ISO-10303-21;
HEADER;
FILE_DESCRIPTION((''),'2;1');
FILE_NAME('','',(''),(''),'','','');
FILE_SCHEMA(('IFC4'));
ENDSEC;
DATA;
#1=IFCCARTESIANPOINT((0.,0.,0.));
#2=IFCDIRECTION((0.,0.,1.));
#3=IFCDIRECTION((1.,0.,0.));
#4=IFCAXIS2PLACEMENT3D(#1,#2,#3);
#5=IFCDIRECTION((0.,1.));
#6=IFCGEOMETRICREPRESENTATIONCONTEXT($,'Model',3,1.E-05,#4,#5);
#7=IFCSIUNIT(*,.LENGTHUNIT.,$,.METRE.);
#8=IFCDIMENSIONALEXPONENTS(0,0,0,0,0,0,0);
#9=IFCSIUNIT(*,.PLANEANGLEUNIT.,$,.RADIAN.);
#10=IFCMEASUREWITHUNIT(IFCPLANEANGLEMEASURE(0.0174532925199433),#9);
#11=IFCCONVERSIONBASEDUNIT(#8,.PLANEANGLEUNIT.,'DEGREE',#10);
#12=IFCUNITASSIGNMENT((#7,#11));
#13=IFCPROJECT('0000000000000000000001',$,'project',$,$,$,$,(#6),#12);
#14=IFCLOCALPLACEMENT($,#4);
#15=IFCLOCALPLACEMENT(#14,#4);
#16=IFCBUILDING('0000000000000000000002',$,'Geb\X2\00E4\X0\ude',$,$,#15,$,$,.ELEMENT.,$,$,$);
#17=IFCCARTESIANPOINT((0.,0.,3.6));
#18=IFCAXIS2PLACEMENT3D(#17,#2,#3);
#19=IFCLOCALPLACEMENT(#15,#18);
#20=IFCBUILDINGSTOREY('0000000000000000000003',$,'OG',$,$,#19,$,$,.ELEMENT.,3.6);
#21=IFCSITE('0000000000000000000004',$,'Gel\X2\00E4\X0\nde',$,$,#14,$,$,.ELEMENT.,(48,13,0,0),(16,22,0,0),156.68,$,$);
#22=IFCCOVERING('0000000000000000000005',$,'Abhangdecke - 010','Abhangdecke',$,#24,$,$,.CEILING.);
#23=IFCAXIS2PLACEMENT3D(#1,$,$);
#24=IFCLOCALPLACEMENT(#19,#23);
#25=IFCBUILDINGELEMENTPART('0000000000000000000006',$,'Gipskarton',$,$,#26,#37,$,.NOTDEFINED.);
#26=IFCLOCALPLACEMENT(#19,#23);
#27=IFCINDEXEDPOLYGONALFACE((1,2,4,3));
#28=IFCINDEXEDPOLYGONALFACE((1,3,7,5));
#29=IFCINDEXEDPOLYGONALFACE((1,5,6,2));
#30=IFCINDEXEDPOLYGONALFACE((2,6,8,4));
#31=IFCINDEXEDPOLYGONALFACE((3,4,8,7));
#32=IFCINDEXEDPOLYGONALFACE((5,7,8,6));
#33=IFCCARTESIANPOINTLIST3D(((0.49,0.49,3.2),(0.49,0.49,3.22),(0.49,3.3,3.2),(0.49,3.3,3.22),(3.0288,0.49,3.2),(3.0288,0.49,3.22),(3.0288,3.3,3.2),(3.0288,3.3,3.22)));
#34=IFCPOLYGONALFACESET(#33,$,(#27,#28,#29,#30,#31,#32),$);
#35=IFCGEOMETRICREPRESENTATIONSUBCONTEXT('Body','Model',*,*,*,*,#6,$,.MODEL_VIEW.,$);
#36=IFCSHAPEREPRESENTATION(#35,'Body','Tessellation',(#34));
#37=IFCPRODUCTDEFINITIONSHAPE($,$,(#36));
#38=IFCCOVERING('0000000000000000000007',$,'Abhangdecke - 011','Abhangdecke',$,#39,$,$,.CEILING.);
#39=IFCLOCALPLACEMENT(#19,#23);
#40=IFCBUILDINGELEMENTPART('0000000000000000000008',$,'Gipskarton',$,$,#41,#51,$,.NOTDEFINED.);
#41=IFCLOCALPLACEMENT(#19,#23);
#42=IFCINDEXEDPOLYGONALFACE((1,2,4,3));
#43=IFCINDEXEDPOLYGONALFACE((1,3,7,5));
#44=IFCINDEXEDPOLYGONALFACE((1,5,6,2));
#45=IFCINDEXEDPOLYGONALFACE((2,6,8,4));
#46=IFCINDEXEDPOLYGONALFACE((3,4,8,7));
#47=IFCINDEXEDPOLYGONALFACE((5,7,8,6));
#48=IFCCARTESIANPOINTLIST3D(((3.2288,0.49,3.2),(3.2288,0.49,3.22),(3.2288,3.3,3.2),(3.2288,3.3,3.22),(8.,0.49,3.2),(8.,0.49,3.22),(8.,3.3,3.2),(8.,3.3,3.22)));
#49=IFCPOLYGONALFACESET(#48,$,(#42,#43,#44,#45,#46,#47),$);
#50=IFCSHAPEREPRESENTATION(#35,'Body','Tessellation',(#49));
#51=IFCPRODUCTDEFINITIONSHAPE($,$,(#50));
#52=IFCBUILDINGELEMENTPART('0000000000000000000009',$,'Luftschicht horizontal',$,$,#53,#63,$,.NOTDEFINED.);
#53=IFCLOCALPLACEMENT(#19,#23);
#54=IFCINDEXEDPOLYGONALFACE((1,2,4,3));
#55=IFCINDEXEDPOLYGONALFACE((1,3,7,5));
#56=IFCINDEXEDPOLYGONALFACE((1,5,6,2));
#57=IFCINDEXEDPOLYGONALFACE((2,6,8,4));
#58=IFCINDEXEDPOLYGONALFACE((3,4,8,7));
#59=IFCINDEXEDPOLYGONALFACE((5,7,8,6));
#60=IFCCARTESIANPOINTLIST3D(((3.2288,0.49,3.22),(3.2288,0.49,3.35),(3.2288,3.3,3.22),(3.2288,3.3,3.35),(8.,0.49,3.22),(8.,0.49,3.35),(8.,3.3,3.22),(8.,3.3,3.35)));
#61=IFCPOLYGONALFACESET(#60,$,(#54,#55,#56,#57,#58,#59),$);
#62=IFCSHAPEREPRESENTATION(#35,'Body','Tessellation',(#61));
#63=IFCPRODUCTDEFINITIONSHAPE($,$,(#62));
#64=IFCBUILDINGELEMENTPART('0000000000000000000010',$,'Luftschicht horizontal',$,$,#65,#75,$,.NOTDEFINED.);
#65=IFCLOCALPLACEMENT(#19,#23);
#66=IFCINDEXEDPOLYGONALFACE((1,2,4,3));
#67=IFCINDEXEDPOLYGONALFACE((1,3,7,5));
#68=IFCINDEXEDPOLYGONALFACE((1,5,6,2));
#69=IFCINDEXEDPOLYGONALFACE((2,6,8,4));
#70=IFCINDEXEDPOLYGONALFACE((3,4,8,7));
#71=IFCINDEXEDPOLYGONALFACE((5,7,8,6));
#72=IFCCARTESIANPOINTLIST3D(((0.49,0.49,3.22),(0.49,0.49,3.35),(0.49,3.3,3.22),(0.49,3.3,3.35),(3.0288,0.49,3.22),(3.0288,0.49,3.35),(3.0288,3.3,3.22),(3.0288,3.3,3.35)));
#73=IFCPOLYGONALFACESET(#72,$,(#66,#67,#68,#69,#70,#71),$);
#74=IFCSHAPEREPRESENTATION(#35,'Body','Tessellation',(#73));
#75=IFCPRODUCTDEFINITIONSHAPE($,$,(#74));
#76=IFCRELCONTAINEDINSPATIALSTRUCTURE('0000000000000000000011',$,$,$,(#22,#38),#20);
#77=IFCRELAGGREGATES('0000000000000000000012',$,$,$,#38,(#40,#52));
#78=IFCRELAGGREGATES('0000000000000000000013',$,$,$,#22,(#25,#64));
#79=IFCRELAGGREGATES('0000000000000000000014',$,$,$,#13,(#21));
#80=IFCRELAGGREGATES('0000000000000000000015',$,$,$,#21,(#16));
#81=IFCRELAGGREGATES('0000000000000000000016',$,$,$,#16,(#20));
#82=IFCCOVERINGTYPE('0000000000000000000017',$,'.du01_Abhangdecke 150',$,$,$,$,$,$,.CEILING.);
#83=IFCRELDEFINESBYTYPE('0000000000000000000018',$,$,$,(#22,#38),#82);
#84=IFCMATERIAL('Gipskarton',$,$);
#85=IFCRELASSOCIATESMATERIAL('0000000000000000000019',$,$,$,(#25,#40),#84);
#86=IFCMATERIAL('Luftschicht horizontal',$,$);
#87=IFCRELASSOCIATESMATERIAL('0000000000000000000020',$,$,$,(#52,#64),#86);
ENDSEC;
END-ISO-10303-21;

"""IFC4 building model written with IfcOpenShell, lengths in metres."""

from ifc_helpers import new_model, entity, si_unit, converted_unit, direction, frame, origin_with_axes, place, context, subcontext, project, spatial, line, indexed_curve, outline, extrude, material, type_object, element, aggregate, save


model = new_model("IFC4")

# Units and contexts
model_context = context("Model", 3, precision=1e-05, world=origin_with_axes(), true_north=direction((0.0, 1.0)))
body_context = subcontext(model_context, "Body", "Model", "MODEL_VIEW")
ifc_project = project(units=[si_unit("LENGTHUNIT", "METRE"), converted_unit("PLANEANGLEUNIT", "DEGREE", entity("IfcPlaneAngleMeasure", 0.0174532925199433), si_unit("PLANEANGLEUNIT", "RADIAN"), dimensions=[0, 0, 0, 0, 0, 0, 0])], contexts=[model_context])

# Site, building, storey
site_placement = place(None, origin_with_axes())
site = spatial("IfcSite", under=ifc_project, at=site_placement, Name="Gelände", CompositionType="ELEMENT", RefLatitude=(48, 13, 0, 0), RefLongitude=(16, 22, 0, 0), RefElevation=156.68)
building_placement = place(site_placement, origin_with_axes())
building = spatial("IfcBuilding", under=site, at=building_placement, Name="Gebäude", CompositionType="ELEMENT")
storey_placement = place(building_placement, frame((0.0, 0.0, 3.6), z_axis=(0.0, 0.0, 1.0), x_axis=(1.0, 0.0, 0.0)))
storey = spatial("IfcBuildingStorey", under=building, at=storey_placement, Name="OG", CompositionType="ELEMENT", Elevation=3.6)

# Shared definitions
ifc_material_1 = material(Name="Gipskarton")
ifc_material_2 = material(Name="Luftschicht horizontal")

# Covering, building element part
covering_type_1 = type_object("IfcCoveringType", Name=".du01_Abhangdecke 150", PredefinedType="CEILING")
covering_1_placement = place(storey_placement, frame((0.49, 3.3, 3.35), z_axis=(0.0, 0.0, 1.0), x_axis=(1.0, 0.0, 0.0)))
covering_1 = element("IfcCovering", 1, at=covering_1_placement, inside=storey, type_object=covering_type_1, Name="Abhangdecke - 010", Description="Abhangdecke", PredefinedType="CEILING")
building_element_part_1_placement = place(covering_1_placement, origin_with_axes())
building_element_part_1 = element("IfcBuildingElementPart", 2, at=building_element_part_1_placement, material=ifc_material_1, Name="Gipskarton", PredefinedType="NOTDEFINED", context=body_context, shape_type="SweptSolid", body=[
    extrude(outline(indexed_curve([(0.0, 0.0), (0.0, -2.81), (2.5388, -2.81), (2.5388, 0.0)], segments=[line(1, 2, 3, 4, 1)])), frame((0.0, 0.0, -0.15), z_axis=(0.0, 0.0, 1.0), x_axis=(1.0, 0.0, 0.0)), (0.0, 0.0, 1.0), 0.02),
])

# Covering, building element parts
covering_2_placement = place(storey_placement, frame((3.2288, 3.3, 3.35), z_axis=(0.0, 0.0, 1.0), x_axis=(1.0, 0.0, 0.0)))
covering_2 = element("IfcCovering", 3, at=covering_2_placement, inside=storey, type_object=covering_type_1, Name="Abhangdecke - 011", Description="Abhangdecke", PredefinedType="CEILING")
building_element_part_2_placement = place(covering_2_placement, origin_with_axes())
building_element_part_2 = element("IfcBuildingElementPart", 4, at=building_element_part_2_placement, material=ifc_material_1, Name="Gipskarton", PredefinedType="NOTDEFINED", context=body_context, shape_type="SweptSolid", body=[
    extrude(outline(indexed_curve([(0.0, 0.0), (0.0, -2.81), (4.7712, -2.81), (4.7712, 0.0)], segments=[line(1, 2, 3, 4, 1)])), frame((0.0, 0.0, -0.15), z_axis=(0.0, 0.0, 1.0), x_axis=(1.0, 0.0, 0.0)), (0.0, 0.0, 1.0), 0.02),
])
building_element_part_3_placement = place(covering_2_placement, origin_with_axes())
building_element_part_3 = element("IfcBuildingElementPart", 5, at=building_element_part_3_placement, material=ifc_material_2, Name="Luftschicht horizontal", PredefinedType="NOTDEFINED", context=body_context, shape_type="SweptSolid", body=[
    extrude(outline(indexed_curve([(0.0, 0.0), (0.0, -2.81), (4.7712, -2.81), (4.7712, 0.0)], segments=[line(1, 2, 3, 4, 1)])), frame((0.0, 0.0, -0.13), z_axis=(0.0, 0.0, 1.0), x_axis=(1.0, 0.0, 0.0)), (0.0, 0.0, 1.0), 0.13),
])
aggregate(covering_2, [building_element_part_2, building_element_part_3])

# Building element part
building_element_part_4_placement = place(covering_1_placement, origin_with_axes())
building_element_part_4 = element("IfcBuildingElementPart", 6, at=building_element_part_4_placement, material=ifc_material_2, Name="Luftschicht horizontal", PredefinedType="NOTDEFINED", context=body_context, shape_type="SweptSolid", body=[
    extrude(outline(indexed_curve([(0.0, 0.0), (0.0, -2.81), (2.5388, -2.81), (2.5388, 0.0)], segments=[line(1, 2, 3, 4, 1)])), frame((0.0, 0.0, -0.13), z_axis=(0.0, 0.0, 1.0), x_axis=(1.0, 0.0, 0.0)), (0.0, 0.0, 1.0), 0.13),
])
aggregate(covering_1, [building_element_part_1, building_element_part_4])

save(model, "model.ifc")
